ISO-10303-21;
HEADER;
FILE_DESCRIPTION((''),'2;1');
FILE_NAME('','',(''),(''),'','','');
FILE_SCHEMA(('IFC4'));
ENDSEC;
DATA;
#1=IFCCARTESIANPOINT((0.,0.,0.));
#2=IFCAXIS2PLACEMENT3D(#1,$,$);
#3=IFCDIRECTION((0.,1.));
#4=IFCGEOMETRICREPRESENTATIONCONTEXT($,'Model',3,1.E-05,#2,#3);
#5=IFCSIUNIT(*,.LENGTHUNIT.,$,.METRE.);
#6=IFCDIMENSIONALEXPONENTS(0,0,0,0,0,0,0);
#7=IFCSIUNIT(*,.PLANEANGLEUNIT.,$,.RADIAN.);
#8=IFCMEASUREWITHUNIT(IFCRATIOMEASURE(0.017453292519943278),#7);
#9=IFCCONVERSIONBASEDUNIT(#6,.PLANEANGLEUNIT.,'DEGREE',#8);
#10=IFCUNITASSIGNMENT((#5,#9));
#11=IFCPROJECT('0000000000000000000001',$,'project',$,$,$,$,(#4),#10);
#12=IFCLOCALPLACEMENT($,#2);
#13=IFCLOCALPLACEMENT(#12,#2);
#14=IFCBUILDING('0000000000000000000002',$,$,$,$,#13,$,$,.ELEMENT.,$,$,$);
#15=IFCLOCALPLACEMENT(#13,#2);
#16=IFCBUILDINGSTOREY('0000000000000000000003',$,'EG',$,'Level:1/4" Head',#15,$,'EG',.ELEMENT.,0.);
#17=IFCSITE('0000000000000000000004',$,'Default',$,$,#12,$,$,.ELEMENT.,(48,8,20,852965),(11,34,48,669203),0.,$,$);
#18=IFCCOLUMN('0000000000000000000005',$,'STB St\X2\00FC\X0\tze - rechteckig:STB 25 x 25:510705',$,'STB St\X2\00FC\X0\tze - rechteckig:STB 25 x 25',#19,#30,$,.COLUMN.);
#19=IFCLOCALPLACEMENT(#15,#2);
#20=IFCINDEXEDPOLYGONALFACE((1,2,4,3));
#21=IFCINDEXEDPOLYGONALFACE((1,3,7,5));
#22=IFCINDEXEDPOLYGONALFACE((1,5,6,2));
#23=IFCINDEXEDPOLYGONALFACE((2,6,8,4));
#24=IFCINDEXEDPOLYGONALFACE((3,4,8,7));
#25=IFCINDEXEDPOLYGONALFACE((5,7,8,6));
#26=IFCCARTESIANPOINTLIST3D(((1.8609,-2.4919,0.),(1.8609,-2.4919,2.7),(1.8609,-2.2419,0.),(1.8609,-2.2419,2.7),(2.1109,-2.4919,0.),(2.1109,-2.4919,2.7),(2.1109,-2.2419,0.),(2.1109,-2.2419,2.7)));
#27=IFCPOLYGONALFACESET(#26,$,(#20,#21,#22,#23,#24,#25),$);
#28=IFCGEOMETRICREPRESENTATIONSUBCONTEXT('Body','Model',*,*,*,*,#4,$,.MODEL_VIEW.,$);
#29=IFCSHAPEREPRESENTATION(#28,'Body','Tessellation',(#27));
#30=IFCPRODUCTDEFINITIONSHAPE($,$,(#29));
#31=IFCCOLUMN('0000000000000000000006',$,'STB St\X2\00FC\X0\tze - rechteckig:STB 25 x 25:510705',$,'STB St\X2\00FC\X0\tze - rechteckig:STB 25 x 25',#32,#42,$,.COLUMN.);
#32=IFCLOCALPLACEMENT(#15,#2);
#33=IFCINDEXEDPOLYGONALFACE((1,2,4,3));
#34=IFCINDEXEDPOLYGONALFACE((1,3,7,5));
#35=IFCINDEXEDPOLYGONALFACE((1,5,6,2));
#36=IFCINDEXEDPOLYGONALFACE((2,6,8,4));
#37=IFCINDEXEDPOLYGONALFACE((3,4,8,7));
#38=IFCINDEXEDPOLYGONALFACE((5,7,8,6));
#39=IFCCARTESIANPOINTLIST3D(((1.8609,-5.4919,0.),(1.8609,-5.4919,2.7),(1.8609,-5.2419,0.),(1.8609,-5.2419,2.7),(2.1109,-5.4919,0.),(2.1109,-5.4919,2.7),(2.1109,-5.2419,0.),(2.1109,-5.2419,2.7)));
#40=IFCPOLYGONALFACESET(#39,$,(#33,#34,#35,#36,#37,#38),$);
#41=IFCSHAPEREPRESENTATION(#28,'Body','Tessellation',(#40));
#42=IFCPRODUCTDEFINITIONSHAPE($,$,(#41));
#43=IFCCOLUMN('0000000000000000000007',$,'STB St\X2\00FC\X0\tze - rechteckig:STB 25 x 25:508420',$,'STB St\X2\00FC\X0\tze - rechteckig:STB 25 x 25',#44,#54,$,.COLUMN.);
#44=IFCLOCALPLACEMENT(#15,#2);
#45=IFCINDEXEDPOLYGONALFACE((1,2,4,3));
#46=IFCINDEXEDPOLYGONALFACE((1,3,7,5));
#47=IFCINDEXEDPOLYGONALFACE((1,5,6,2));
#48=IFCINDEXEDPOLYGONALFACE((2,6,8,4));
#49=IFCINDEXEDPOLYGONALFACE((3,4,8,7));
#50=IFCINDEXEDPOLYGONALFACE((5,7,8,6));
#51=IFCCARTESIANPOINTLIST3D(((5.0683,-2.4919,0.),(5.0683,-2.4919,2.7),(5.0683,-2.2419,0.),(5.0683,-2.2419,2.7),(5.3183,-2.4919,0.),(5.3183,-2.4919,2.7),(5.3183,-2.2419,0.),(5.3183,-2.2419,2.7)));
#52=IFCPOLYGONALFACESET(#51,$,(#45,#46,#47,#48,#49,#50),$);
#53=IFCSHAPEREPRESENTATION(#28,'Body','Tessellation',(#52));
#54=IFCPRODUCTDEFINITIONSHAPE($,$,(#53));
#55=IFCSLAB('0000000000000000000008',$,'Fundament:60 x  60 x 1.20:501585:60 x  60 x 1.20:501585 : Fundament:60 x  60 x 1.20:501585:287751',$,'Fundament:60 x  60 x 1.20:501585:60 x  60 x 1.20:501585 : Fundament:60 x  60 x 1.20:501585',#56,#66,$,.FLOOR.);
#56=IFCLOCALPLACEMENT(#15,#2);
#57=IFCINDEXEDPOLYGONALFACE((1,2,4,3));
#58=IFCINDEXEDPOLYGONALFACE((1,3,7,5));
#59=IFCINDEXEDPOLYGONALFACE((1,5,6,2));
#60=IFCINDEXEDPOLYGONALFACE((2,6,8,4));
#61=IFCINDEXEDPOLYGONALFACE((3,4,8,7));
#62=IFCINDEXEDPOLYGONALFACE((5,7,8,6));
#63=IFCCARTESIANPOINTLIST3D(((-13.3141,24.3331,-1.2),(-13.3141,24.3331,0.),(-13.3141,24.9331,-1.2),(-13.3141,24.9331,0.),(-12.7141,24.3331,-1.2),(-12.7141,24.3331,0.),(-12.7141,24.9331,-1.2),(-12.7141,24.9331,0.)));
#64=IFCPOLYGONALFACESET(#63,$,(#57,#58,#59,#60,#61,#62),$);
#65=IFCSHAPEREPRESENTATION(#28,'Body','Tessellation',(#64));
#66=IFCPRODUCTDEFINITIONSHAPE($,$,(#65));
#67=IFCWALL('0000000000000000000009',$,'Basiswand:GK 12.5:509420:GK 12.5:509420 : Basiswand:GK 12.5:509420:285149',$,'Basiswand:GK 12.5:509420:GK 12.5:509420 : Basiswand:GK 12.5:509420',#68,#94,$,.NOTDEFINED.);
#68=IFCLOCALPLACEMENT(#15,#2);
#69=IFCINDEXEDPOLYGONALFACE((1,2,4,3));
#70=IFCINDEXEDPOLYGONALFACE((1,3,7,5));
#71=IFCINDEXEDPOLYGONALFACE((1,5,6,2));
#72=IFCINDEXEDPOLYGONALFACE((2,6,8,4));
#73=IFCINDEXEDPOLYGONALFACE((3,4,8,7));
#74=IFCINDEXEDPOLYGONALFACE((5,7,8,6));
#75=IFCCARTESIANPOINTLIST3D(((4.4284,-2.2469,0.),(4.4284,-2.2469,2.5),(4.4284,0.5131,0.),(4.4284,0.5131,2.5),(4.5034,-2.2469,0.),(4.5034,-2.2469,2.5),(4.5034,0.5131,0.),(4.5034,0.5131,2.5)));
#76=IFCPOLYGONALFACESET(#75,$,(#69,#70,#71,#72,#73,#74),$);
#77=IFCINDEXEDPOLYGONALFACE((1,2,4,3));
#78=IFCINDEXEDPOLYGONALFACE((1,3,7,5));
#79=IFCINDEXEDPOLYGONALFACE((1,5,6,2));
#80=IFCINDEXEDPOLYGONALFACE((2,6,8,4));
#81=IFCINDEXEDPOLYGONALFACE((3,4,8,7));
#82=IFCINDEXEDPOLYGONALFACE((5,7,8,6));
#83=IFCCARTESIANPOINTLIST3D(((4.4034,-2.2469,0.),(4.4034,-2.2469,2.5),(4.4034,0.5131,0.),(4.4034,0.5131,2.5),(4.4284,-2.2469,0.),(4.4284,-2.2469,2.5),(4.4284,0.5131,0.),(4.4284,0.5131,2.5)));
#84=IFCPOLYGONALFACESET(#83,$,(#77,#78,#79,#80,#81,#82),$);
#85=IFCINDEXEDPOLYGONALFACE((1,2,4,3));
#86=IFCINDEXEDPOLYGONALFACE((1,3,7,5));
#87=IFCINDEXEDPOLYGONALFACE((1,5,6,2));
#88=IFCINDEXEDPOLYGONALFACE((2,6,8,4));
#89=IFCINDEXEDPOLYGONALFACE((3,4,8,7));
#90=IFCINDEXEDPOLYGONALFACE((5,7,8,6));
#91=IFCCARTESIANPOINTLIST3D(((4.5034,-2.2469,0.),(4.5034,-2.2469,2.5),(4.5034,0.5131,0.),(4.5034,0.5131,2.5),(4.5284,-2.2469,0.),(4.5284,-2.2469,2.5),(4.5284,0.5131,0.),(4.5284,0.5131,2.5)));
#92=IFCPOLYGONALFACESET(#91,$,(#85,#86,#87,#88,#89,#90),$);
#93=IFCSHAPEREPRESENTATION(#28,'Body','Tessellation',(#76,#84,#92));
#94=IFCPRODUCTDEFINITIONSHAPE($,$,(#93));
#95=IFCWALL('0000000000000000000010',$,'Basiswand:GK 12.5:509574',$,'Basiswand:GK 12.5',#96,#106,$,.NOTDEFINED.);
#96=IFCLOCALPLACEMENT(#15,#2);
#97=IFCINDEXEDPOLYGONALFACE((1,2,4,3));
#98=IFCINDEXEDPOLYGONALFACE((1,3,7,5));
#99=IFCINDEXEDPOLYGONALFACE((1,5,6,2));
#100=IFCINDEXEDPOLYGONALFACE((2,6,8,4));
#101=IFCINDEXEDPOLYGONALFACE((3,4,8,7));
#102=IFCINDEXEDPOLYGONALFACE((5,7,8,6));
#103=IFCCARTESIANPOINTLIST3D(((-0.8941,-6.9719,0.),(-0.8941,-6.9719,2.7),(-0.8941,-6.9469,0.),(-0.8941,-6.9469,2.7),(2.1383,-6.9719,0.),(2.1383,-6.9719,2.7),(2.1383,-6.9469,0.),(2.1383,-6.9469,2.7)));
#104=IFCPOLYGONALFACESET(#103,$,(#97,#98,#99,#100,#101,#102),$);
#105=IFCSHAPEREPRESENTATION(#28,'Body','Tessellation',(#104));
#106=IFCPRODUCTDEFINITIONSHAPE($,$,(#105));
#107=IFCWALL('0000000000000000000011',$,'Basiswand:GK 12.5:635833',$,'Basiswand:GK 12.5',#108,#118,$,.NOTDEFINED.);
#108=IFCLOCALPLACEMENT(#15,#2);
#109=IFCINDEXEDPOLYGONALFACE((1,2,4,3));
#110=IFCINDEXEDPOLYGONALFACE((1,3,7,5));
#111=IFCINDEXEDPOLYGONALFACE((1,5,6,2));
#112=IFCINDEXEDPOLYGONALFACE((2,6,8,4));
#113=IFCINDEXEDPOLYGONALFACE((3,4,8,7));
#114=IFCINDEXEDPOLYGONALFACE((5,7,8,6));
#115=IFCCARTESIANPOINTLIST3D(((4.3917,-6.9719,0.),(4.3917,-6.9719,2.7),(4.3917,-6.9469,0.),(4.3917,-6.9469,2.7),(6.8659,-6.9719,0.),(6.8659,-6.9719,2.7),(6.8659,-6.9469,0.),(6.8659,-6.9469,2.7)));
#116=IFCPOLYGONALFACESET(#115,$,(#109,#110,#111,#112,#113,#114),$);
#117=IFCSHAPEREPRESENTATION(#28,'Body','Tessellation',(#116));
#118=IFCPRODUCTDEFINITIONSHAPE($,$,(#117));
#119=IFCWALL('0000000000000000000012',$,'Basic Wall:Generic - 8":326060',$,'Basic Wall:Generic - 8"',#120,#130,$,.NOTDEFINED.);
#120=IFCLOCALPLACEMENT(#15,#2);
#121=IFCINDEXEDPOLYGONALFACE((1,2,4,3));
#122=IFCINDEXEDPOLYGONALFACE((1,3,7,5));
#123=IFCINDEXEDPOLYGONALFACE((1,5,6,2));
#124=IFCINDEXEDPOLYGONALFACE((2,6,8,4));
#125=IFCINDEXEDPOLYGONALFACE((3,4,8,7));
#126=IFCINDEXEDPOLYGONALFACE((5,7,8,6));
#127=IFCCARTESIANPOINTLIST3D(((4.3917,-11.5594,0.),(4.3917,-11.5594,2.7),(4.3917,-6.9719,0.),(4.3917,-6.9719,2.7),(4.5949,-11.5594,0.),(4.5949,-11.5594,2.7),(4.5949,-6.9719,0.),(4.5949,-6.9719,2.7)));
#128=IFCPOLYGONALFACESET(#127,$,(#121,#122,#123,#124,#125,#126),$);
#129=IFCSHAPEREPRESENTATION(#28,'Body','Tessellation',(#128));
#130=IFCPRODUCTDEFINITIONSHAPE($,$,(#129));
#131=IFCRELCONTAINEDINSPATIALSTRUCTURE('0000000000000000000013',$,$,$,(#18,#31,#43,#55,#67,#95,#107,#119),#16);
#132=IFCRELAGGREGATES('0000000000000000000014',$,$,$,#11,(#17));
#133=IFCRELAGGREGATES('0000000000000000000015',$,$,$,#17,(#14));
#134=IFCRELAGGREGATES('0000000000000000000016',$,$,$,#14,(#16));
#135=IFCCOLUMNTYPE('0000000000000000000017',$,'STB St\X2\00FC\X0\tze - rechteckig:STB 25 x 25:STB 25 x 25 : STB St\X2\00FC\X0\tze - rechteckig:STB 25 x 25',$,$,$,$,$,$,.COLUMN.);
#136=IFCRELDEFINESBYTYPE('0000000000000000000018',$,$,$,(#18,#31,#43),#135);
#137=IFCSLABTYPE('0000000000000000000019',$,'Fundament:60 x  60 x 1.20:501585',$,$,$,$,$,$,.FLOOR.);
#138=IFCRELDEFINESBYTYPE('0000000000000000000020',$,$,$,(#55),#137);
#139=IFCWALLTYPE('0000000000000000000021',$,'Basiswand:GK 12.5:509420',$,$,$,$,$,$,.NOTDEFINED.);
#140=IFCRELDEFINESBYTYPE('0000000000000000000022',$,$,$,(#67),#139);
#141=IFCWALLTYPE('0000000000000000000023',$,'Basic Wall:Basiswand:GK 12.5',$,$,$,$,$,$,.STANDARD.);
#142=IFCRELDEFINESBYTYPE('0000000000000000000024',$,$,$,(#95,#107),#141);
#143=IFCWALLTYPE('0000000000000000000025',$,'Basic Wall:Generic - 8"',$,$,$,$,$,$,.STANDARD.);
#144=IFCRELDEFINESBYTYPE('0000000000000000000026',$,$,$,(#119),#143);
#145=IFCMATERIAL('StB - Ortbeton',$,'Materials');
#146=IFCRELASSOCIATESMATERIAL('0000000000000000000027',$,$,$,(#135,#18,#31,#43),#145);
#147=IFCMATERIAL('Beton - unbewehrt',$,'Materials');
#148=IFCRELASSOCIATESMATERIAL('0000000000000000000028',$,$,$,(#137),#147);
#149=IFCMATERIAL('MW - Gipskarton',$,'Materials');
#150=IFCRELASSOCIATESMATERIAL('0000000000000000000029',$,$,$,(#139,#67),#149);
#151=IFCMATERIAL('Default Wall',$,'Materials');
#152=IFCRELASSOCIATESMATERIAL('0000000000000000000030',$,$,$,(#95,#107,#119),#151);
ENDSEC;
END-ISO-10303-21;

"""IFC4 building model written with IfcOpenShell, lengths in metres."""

from ifc_helpers import new_model, entity, si_unit, converted_unit, direction, frame, origin, place, context, subcontext, project, spatial, indexed_curve, outline, extrude, source, transform, mapped, material, type_object, type_shapes, element, save


model = new_model("IFC4")

# Units and contexts
model_context = context("Model", 3, precision=1e-05, world=origin(), true_north=direction((0.0, 1.0)))
body_context = subcontext(model_context, "Body", "Model", "MODEL_VIEW")
ifc_project = project(units=[si_unit("LENGTHUNIT", "METRE"), converted_unit("PLANEANGLEUNIT", "DEGREE", entity("IfcRatioMeasure", 0.017453292519943278), si_unit("PLANEANGLEUNIT", "RADIAN"), dimensions=[0, 0, 0, 0, 0, 0, 0])], contexts=[model_context])

# Site, building, storey
site_placement = place(None, origin())
site = spatial("IfcSite", under=ifc_project, at=site_placement, Name="Default", CompositionType="ELEMENT", RefLatitude=(48, 8, 20, 852965), RefLongitude=(11, 34, 48, 669203), RefElevation=0.0)
building_placement = place(site_placement, origin())
building = spatial("IfcBuilding", under=site, at=building_placement, CompositionType="ELEMENT")
storey_placement = place(building_placement, origin())
storey = spatial("IfcBuildingStorey", under=building, at=storey_placement, Name="EG", ObjectType="Level:1/4\" Head", LongName="EG", CompositionType="ELEMENT", Elevation=0.0)

# Columns
ifc_material_1 = material(Name="StB - Ortbeton", Category="Materials")
column_type = type_object("IfcColumnType", Name="STB Stütze - rechteckig:STB 25 x 25:STB 25 x 25 : STB Stütze - rechteckig:STB 25 x 25", PredefinedType="COLUMN", material=ifc_material_1)
shared_shape_1 = source(origin(), body_context, "Body", "SweptSolid", [
    extrude(outline(indexed_curve([(-0.125, -0.125), (0.125, -0.125), (0.125, 0.125), (-0.125, 0.125), (-0.125, -0.125)], self_intersect=False)), frame((0.0, 0.0, 0.0), z_axis=(0.0, 0.0, 1.0), x_axis=(0.0, -1.0, 0.0)), (0.0, 0.0, 1.0), 2.7),
])
type_shapes(column_type, [shared_shape_1])
for number, where, name in (
    (1, (1.9859, -2.3669, 0.0), "STB Stütze - rechteckig:STB 25 x 25:510705"),
    (2, (1.9859, -5.3669, 0.0), "STB Stütze - rechteckig:STB 25 x 25:510705"),
    (3, (5.1933, -2.3669, 0.0), "STB Stütze - rechteckig:STB 25 x 25:508420"),
):
    element("IfcColumn", number, at=place(storey_placement, frame(where)), inside=storey, type_object=column_type, material=ifc_material_1, Name=name, ObjectType="STB Stütze - rechteckig:STB 25 x 25", PredefinedType="COLUMN", context=body_context, shape_type="MappedRepresentation", body=[
        mapped(shared_shape_1, transform((0.0, 0.0, 0.0), scale=1.0)),
    ])

# Slab
ifc_material_2 = material(Name="Beton - unbewehrt", Category="Materials")
slab_type = type_object("IfcSlabType", Name="Fundament:60 x  60 x 1.20:501585", PredefinedType="FLOOR", material=ifc_material_2)
slab_placement = place(storey_placement, origin())
element("IfcSlab", 4, at=slab_placement, inside=storey, type_object=slab_type, Name="Fundament:60 x  60 x 1.20:501585:60 x  60 x 1.20:501585 : Fundament:60 x  60 x 1.20:501585:287751", ObjectType="Fundament:60 x  60 x 1.20:501585:60 x  60 x 1.20:501585 : Fundament:60 x  60 x 1.20:501585", PredefinedType="FLOOR", context=body_context, shape_type="SweptSolid", body=[
    extrude(outline(indexed_curve([(-0.3, -0.3), (0.3, -0.3), (0.3, 0.3), (-0.3, 0.3), (-0.3, -0.3)], self_intersect=False)), frame((-13.0141, 24.6331, -1.2), z_axis=(0.0, 0.0, 1.0), x_axis=(0.0, -1.0, 0.0)), (0.0, 0.0, 1.0), 1.2),
])

# Walls
ifc_material_3 = material(Name="MW - Gipskarton", Category="Materials")
wall_type_1 = type_object("IfcWallType", Name="Basiswand:GK 12.5:509420", PredefinedType="NOTDEFINED", material=ifc_material_3)
wall_1_placement = place(storey_placement, frame((4.4034, -2.2469, 0.0), z_axis=(0.0, 0.0, 1.0), x_axis=(0.0, 1.0, 0.0)))
element("IfcWall", 5, at=wall_1_placement, inside=storey, type_object=wall_type_1, material=ifc_material_3, Name="Basiswand:GK 12.5:509420:GK 12.5:509420 : Basiswand:GK 12.5:509420:285149", ObjectType="Basiswand:GK 12.5:509420:GK 12.5:509420 : Basiswand:GK 12.5:509420", PredefinedType="NOTDEFINED", context=body_context, shape_type="SweptSolid", body=[
    extrude(outline(indexed_curve([(-0.0375, -1.38), (0.0375, -1.38), (0.0375, 1.38), (-0.0375, 1.38), (-0.0375, -1.38)], self_intersect=False)), frame((1.38, -0.0625, 0.0), z_axis=(0.0, 0.0, 1.0), x_axis=(0.0, 1.0, 0.0)), (0.0, 0.0, 1.0), 2.5),
    extrude(outline(indexed_curve([(-0.0125, -1.38), (0.0125, -1.38), (0.0125, 1.38), (-0.0125, 1.38), (-0.0125, -1.38)], self_intersect=False)), frame((1.38, -0.0125, 0.0), z_axis=(0.0, 0.0, 1.0), x_axis=(0.0, 1.0, 0.0)), (0.0, 0.0, 1.0), 2.5),
    extrude(outline(indexed_curve([(-0.0125, -1.38), (0.0125, -1.38), (0.0125, 1.38), (-0.0125, 1.38), (-0.0125, -1.38)], self_intersect=False)), frame((1.38, -0.1125, 0.0), z_axis=(0.0, 0.0, 1.0), x_axis=(0.0, 1.0, 0.0)), (0.0, 0.0, 1.0), 2.5),
])
ifc_material_4 = material(Name="Default Wall", Category="Materials")
wall_type_2 = type_object("IfcWallType", Name="Basic Wall:Basiswand:GK 12.5", PredefinedType="STANDARD")
wall_2_placement = place(storey_placement, frame((2.1383, -6.9594, 0.0), z_axis=(0.0, 0.0, 1.0), x_axis=(-1.0, 0.0, 0.0)))
element("IfcWall", 6, at=wall_2_placement, inside=storey, type_object=wall_type_2, material=ifc_material_4, Name="Basiswand:GK 12.5:509574", ObjectType="Basiswand:GK 12.5", PredefinedType="NOTDEFINED", context=body_context, shape_type="SweptSolid", body=[
    extrude(outline(indexed_curve([(3.0324, 0.0125), (0.0, 0.0125), (0.0, -0.0125), (3.0324, -0.0125), (3.0324, 0.0125)], self_intersect=False)), origin(), (0.0, 0.0, 1.0), 2.7),
])
wall_3_placement = place(storey_placement, frame((4.3917, -6.9594, 0.0)))
element("IfcWall", 7, at=wall_3_placement, inside=storey, type_object=wall_type_2, material=ifc_material_4, Name="Basiswand:GK 12.5:635833", ObjectType="Basiswand:GK 12.5", PredefinedType="NOTDEFINED", context=body_context, shape_type="SweptSolid", body=[
    extrude(outline(indexed_curve([(2.4743, 0.0125), (0.0, 0.0125), (0.0, -0.0125), (2.4743, -0.0125), (2.4743, 0.0125)], self_intersect=False)), origin(), (0.0, 0.0, 1.0), 2.7),
])
wall_type_3 = type_object("IfcWallType", Name="Basic Wall:Generic - 8\"", PredefinedType="STANDARD")
wall_4_placement = place(storey_placement, frame((4.4933, -6.9719, 0.0), z_axis=(0.0, 0.0, 1.0), x_axis=(0.0, -1.0, 0.0)))
element("IfcWall", 8, at=wall_4_placement, inside=storey, type_object=wall_type_3, material=ifc_material_4, Name="Basic Wall:Generic - 8\":326060", ObjectType="Basic Wall:Generic - 8\"", PredefinedType="NOTDEFINED", context=body_context, shape_type="SweptSolid", body=[
    extrude(outline(indexed_curve([(4.5875, 0.1016), (0.0, 0.1016), (0.0, -0.1016), (4.5875, -0.1016), (4.5875, 0.1016)], self_intersect=False)), origin(), (0.0, 0.0, 1.0), 2.7),
])

save(model, "model.ifc")
